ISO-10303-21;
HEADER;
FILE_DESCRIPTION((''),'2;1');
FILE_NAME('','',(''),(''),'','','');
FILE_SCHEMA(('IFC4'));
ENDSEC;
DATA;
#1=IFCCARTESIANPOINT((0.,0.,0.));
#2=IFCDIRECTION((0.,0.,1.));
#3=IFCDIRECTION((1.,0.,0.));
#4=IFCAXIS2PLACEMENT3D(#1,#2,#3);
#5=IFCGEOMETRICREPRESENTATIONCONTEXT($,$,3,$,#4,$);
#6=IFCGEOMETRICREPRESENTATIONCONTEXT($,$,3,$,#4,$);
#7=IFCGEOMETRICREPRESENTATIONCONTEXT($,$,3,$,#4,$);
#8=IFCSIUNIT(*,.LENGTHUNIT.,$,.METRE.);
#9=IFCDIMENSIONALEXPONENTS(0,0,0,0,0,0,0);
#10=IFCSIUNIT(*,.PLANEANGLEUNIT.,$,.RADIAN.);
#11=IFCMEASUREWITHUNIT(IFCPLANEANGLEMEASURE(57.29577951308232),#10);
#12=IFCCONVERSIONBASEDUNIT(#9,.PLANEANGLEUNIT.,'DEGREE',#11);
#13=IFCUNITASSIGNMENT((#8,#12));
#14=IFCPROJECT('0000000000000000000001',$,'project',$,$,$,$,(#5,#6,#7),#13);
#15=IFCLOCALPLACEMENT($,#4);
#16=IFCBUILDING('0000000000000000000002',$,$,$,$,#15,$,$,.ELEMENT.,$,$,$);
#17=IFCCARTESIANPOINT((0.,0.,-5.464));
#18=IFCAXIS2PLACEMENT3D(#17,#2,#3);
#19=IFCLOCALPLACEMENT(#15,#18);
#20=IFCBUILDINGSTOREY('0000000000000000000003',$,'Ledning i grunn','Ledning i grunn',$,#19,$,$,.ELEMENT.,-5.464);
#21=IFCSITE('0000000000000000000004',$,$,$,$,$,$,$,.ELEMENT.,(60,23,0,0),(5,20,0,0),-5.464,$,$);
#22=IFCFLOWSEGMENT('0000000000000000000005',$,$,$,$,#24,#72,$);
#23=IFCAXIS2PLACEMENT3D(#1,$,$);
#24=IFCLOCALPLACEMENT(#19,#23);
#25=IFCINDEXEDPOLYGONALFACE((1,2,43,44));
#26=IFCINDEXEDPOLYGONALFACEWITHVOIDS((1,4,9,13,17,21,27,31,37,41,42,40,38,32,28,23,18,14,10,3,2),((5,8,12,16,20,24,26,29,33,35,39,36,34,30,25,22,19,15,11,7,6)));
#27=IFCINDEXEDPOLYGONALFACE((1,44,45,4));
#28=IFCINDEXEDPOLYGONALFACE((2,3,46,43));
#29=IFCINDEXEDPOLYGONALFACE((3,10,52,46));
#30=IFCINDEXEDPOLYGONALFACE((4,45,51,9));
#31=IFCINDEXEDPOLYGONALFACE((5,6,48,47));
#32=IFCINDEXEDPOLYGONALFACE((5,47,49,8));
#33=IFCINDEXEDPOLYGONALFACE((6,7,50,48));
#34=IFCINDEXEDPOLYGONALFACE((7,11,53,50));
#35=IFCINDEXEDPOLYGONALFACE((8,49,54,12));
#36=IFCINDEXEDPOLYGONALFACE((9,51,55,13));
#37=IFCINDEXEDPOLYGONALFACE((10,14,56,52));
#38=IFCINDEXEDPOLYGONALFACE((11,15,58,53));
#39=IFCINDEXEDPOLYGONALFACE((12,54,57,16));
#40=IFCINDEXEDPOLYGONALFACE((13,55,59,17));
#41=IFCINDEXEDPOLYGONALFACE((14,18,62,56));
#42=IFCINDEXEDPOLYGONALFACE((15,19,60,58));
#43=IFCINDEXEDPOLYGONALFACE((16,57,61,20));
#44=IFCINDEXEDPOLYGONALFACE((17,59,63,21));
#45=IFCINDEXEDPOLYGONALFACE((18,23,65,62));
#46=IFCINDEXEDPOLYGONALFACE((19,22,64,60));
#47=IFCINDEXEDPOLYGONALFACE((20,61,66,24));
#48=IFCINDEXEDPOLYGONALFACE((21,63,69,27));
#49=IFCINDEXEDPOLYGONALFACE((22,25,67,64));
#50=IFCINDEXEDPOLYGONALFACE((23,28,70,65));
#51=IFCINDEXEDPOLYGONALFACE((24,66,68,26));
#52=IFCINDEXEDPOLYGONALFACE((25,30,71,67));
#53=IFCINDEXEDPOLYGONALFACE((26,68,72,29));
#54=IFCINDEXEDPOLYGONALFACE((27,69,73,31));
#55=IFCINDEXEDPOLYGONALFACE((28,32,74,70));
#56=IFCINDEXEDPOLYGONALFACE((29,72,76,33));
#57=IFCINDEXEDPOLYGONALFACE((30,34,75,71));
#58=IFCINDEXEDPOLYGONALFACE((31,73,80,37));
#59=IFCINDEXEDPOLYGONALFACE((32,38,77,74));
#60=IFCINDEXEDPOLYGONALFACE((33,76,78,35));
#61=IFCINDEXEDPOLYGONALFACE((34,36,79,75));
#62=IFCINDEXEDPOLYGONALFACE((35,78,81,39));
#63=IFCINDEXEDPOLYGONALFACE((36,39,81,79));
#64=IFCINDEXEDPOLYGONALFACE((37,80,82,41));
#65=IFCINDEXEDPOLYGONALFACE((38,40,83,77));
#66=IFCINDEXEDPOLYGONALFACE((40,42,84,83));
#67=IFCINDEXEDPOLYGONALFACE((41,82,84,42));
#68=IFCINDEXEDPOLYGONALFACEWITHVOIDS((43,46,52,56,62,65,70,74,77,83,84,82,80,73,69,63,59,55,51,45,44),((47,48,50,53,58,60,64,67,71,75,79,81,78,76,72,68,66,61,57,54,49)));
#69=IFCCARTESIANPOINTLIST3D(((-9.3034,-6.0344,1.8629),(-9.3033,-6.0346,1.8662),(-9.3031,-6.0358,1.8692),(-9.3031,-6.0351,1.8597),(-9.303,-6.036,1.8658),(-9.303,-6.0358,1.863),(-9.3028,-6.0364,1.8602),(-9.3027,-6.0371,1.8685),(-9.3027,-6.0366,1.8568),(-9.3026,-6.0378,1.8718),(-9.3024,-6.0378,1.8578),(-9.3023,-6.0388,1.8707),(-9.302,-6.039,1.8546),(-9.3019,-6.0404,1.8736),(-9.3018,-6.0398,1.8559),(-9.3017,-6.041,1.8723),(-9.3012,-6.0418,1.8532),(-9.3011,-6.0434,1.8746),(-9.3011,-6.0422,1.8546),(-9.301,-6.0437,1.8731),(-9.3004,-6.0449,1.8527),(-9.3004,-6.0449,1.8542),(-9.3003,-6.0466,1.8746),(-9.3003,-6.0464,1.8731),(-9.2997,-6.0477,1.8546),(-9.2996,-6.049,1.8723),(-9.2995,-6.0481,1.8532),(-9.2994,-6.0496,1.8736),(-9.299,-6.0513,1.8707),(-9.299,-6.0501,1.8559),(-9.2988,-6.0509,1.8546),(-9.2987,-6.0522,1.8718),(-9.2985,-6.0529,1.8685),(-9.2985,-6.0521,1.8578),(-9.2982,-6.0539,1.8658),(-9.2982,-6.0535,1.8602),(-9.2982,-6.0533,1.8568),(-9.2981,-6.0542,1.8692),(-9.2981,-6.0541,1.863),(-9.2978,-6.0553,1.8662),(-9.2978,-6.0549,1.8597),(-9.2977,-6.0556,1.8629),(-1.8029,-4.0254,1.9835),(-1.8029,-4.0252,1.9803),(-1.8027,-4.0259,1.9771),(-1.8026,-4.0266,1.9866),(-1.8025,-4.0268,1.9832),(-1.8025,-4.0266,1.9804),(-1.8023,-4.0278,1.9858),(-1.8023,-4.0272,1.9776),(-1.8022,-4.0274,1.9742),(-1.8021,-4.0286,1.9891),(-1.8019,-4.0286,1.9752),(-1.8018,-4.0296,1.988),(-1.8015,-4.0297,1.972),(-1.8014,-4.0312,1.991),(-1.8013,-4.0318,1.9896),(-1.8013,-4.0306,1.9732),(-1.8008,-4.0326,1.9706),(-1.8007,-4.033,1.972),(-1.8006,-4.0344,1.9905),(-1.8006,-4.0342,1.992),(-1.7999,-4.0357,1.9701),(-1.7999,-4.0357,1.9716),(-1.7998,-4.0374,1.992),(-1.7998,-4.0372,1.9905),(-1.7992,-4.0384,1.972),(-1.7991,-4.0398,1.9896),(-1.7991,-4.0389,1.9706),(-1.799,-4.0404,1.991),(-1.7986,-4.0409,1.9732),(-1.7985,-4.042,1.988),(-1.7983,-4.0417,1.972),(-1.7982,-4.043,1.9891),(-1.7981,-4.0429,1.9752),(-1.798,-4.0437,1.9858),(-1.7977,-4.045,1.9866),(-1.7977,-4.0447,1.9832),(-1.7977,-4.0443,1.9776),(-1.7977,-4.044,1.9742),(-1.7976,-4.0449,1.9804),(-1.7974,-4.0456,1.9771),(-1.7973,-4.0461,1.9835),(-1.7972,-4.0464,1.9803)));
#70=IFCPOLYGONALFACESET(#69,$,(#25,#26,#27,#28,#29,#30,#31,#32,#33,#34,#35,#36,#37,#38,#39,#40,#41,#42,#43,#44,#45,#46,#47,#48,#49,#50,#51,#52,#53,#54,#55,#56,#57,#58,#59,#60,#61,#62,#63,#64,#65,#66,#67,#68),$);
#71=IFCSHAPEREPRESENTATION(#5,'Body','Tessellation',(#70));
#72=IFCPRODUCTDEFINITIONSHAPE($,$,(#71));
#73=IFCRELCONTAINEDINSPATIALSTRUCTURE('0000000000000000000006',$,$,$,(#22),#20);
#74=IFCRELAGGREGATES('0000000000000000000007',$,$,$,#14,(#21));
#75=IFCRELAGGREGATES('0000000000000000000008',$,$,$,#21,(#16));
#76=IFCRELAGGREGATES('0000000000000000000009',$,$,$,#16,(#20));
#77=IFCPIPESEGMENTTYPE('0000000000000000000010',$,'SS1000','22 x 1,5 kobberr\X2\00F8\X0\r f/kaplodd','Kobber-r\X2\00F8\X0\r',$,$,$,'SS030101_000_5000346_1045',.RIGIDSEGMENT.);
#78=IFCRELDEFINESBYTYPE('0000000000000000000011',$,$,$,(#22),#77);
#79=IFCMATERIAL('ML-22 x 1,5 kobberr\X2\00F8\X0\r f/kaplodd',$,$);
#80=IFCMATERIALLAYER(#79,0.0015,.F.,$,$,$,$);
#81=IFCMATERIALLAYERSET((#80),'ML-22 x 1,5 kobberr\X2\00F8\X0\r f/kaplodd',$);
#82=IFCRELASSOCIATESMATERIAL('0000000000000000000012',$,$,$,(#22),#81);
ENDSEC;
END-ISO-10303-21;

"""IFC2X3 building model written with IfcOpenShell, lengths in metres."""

from ifc_helpers import new_model, entity, si_unit, converted_unit, frame, origin_with_axes, origin_2d_with_axis, place, context, project, spatial, hollow_circle, extrude, material, layer, layer_set, layer_usage, type_object, element, save


model = new_model("IFC2X3")

# Units and contexts
context_of_model_1 = context(None, 3, world=origin_with_axes())
context_of_model_2 = context(None, 3, world=origin_with_axes())
context_of_model_3 = context(None, 3, world=origin_with_axes())
ifc_project = project(units=[si_unit("LENGTHUNIT", "METRE"), converted_unit("PLANEANGLEUNIT", "DEGREE", entity("IfcPlaneAngleMeasure", 57.29577951308232), si_unit("PLANEANGLEUNIT", "RADIAN"), dimensions=[0, 0, 0, 0, 0, 0, 0])], contexts=[context_of_model_1, context_of_model_2, context_of_model_3])

# Site, building, storey
site = spatial("IfcSite", under=ifc_project, CompositionType="ELEMENT", RefLatitude=(60, 23, 0, 0), RefLongitude=(5, 20, 0, 0), RefElevation=-5.464)
building_placement = place(None, origin_with_axes())
building = spatial("IfcBuilding", under=site, at=building_placement, CompositionType="ELEMENT")
storey_placement = place(building_placement, frame((0.0, 0.0, -5.464), z_axis=(0.0, 0.0, 1.0), x_axis=(1.0, 0.0, 0.0)))
storey = spatial("IfcBuildingStorey", under=building, at=storey_placement, Name="Ledning i grunn", Description="Ledning i grunn", CompositionType="ELEMENT", Elevation=-5.464)

# Flow segment
pipe_segment_type_1 = type_object("IfcPipeSegmentType", Name="SS1000", Description="22 x 1,5 kobberrør f/kaplodd", ApplicableOccurrence="Kobber-rør", ElementType="SS030101_000_5000346_1045", PredefinedType="RIGIDSEGMENT")
ifc_material_1 = material(Name="ML-22 x 1,5 kobberrør f/kaplodd")
ifc_layer_1 = layer(ifc_material_1, 0.0015, ventilated=False)
ifc_layer_set_1 = layer_set([ifc_layer_1], Name="ML-22 x 1,5 kobberrør f/kaplodd")
ifc_layer_usage_1 = layer_usage(ifc_layer_set_1, "AXIS2", "POSITIVE", 0.0)
flow_segment_1_placement = place(storey_placement, frame((-1.8001, -4.0358, 1.9811), z_axis=(-0.965833, -0.258726, -0.015114), x_axis=(0.014599, 0.003911, -0.999886)))
element("IfcFlowSegment", 1, at=flow_segment_1_placement, inside=storey, type_object=pipe_segment_type_1, material=ifc_layer_usage_1, context=context_of_model_1, shape_type="SweptSolid", body=[
    extrude(hollow_circle(Radius=0.011, WallThickness=0.0015, at=origin_2d_with_axis()), origin_with_axes(), (0.0, 0.0, 1.0), 7.7658),
])

save(model, "model.ifc")
